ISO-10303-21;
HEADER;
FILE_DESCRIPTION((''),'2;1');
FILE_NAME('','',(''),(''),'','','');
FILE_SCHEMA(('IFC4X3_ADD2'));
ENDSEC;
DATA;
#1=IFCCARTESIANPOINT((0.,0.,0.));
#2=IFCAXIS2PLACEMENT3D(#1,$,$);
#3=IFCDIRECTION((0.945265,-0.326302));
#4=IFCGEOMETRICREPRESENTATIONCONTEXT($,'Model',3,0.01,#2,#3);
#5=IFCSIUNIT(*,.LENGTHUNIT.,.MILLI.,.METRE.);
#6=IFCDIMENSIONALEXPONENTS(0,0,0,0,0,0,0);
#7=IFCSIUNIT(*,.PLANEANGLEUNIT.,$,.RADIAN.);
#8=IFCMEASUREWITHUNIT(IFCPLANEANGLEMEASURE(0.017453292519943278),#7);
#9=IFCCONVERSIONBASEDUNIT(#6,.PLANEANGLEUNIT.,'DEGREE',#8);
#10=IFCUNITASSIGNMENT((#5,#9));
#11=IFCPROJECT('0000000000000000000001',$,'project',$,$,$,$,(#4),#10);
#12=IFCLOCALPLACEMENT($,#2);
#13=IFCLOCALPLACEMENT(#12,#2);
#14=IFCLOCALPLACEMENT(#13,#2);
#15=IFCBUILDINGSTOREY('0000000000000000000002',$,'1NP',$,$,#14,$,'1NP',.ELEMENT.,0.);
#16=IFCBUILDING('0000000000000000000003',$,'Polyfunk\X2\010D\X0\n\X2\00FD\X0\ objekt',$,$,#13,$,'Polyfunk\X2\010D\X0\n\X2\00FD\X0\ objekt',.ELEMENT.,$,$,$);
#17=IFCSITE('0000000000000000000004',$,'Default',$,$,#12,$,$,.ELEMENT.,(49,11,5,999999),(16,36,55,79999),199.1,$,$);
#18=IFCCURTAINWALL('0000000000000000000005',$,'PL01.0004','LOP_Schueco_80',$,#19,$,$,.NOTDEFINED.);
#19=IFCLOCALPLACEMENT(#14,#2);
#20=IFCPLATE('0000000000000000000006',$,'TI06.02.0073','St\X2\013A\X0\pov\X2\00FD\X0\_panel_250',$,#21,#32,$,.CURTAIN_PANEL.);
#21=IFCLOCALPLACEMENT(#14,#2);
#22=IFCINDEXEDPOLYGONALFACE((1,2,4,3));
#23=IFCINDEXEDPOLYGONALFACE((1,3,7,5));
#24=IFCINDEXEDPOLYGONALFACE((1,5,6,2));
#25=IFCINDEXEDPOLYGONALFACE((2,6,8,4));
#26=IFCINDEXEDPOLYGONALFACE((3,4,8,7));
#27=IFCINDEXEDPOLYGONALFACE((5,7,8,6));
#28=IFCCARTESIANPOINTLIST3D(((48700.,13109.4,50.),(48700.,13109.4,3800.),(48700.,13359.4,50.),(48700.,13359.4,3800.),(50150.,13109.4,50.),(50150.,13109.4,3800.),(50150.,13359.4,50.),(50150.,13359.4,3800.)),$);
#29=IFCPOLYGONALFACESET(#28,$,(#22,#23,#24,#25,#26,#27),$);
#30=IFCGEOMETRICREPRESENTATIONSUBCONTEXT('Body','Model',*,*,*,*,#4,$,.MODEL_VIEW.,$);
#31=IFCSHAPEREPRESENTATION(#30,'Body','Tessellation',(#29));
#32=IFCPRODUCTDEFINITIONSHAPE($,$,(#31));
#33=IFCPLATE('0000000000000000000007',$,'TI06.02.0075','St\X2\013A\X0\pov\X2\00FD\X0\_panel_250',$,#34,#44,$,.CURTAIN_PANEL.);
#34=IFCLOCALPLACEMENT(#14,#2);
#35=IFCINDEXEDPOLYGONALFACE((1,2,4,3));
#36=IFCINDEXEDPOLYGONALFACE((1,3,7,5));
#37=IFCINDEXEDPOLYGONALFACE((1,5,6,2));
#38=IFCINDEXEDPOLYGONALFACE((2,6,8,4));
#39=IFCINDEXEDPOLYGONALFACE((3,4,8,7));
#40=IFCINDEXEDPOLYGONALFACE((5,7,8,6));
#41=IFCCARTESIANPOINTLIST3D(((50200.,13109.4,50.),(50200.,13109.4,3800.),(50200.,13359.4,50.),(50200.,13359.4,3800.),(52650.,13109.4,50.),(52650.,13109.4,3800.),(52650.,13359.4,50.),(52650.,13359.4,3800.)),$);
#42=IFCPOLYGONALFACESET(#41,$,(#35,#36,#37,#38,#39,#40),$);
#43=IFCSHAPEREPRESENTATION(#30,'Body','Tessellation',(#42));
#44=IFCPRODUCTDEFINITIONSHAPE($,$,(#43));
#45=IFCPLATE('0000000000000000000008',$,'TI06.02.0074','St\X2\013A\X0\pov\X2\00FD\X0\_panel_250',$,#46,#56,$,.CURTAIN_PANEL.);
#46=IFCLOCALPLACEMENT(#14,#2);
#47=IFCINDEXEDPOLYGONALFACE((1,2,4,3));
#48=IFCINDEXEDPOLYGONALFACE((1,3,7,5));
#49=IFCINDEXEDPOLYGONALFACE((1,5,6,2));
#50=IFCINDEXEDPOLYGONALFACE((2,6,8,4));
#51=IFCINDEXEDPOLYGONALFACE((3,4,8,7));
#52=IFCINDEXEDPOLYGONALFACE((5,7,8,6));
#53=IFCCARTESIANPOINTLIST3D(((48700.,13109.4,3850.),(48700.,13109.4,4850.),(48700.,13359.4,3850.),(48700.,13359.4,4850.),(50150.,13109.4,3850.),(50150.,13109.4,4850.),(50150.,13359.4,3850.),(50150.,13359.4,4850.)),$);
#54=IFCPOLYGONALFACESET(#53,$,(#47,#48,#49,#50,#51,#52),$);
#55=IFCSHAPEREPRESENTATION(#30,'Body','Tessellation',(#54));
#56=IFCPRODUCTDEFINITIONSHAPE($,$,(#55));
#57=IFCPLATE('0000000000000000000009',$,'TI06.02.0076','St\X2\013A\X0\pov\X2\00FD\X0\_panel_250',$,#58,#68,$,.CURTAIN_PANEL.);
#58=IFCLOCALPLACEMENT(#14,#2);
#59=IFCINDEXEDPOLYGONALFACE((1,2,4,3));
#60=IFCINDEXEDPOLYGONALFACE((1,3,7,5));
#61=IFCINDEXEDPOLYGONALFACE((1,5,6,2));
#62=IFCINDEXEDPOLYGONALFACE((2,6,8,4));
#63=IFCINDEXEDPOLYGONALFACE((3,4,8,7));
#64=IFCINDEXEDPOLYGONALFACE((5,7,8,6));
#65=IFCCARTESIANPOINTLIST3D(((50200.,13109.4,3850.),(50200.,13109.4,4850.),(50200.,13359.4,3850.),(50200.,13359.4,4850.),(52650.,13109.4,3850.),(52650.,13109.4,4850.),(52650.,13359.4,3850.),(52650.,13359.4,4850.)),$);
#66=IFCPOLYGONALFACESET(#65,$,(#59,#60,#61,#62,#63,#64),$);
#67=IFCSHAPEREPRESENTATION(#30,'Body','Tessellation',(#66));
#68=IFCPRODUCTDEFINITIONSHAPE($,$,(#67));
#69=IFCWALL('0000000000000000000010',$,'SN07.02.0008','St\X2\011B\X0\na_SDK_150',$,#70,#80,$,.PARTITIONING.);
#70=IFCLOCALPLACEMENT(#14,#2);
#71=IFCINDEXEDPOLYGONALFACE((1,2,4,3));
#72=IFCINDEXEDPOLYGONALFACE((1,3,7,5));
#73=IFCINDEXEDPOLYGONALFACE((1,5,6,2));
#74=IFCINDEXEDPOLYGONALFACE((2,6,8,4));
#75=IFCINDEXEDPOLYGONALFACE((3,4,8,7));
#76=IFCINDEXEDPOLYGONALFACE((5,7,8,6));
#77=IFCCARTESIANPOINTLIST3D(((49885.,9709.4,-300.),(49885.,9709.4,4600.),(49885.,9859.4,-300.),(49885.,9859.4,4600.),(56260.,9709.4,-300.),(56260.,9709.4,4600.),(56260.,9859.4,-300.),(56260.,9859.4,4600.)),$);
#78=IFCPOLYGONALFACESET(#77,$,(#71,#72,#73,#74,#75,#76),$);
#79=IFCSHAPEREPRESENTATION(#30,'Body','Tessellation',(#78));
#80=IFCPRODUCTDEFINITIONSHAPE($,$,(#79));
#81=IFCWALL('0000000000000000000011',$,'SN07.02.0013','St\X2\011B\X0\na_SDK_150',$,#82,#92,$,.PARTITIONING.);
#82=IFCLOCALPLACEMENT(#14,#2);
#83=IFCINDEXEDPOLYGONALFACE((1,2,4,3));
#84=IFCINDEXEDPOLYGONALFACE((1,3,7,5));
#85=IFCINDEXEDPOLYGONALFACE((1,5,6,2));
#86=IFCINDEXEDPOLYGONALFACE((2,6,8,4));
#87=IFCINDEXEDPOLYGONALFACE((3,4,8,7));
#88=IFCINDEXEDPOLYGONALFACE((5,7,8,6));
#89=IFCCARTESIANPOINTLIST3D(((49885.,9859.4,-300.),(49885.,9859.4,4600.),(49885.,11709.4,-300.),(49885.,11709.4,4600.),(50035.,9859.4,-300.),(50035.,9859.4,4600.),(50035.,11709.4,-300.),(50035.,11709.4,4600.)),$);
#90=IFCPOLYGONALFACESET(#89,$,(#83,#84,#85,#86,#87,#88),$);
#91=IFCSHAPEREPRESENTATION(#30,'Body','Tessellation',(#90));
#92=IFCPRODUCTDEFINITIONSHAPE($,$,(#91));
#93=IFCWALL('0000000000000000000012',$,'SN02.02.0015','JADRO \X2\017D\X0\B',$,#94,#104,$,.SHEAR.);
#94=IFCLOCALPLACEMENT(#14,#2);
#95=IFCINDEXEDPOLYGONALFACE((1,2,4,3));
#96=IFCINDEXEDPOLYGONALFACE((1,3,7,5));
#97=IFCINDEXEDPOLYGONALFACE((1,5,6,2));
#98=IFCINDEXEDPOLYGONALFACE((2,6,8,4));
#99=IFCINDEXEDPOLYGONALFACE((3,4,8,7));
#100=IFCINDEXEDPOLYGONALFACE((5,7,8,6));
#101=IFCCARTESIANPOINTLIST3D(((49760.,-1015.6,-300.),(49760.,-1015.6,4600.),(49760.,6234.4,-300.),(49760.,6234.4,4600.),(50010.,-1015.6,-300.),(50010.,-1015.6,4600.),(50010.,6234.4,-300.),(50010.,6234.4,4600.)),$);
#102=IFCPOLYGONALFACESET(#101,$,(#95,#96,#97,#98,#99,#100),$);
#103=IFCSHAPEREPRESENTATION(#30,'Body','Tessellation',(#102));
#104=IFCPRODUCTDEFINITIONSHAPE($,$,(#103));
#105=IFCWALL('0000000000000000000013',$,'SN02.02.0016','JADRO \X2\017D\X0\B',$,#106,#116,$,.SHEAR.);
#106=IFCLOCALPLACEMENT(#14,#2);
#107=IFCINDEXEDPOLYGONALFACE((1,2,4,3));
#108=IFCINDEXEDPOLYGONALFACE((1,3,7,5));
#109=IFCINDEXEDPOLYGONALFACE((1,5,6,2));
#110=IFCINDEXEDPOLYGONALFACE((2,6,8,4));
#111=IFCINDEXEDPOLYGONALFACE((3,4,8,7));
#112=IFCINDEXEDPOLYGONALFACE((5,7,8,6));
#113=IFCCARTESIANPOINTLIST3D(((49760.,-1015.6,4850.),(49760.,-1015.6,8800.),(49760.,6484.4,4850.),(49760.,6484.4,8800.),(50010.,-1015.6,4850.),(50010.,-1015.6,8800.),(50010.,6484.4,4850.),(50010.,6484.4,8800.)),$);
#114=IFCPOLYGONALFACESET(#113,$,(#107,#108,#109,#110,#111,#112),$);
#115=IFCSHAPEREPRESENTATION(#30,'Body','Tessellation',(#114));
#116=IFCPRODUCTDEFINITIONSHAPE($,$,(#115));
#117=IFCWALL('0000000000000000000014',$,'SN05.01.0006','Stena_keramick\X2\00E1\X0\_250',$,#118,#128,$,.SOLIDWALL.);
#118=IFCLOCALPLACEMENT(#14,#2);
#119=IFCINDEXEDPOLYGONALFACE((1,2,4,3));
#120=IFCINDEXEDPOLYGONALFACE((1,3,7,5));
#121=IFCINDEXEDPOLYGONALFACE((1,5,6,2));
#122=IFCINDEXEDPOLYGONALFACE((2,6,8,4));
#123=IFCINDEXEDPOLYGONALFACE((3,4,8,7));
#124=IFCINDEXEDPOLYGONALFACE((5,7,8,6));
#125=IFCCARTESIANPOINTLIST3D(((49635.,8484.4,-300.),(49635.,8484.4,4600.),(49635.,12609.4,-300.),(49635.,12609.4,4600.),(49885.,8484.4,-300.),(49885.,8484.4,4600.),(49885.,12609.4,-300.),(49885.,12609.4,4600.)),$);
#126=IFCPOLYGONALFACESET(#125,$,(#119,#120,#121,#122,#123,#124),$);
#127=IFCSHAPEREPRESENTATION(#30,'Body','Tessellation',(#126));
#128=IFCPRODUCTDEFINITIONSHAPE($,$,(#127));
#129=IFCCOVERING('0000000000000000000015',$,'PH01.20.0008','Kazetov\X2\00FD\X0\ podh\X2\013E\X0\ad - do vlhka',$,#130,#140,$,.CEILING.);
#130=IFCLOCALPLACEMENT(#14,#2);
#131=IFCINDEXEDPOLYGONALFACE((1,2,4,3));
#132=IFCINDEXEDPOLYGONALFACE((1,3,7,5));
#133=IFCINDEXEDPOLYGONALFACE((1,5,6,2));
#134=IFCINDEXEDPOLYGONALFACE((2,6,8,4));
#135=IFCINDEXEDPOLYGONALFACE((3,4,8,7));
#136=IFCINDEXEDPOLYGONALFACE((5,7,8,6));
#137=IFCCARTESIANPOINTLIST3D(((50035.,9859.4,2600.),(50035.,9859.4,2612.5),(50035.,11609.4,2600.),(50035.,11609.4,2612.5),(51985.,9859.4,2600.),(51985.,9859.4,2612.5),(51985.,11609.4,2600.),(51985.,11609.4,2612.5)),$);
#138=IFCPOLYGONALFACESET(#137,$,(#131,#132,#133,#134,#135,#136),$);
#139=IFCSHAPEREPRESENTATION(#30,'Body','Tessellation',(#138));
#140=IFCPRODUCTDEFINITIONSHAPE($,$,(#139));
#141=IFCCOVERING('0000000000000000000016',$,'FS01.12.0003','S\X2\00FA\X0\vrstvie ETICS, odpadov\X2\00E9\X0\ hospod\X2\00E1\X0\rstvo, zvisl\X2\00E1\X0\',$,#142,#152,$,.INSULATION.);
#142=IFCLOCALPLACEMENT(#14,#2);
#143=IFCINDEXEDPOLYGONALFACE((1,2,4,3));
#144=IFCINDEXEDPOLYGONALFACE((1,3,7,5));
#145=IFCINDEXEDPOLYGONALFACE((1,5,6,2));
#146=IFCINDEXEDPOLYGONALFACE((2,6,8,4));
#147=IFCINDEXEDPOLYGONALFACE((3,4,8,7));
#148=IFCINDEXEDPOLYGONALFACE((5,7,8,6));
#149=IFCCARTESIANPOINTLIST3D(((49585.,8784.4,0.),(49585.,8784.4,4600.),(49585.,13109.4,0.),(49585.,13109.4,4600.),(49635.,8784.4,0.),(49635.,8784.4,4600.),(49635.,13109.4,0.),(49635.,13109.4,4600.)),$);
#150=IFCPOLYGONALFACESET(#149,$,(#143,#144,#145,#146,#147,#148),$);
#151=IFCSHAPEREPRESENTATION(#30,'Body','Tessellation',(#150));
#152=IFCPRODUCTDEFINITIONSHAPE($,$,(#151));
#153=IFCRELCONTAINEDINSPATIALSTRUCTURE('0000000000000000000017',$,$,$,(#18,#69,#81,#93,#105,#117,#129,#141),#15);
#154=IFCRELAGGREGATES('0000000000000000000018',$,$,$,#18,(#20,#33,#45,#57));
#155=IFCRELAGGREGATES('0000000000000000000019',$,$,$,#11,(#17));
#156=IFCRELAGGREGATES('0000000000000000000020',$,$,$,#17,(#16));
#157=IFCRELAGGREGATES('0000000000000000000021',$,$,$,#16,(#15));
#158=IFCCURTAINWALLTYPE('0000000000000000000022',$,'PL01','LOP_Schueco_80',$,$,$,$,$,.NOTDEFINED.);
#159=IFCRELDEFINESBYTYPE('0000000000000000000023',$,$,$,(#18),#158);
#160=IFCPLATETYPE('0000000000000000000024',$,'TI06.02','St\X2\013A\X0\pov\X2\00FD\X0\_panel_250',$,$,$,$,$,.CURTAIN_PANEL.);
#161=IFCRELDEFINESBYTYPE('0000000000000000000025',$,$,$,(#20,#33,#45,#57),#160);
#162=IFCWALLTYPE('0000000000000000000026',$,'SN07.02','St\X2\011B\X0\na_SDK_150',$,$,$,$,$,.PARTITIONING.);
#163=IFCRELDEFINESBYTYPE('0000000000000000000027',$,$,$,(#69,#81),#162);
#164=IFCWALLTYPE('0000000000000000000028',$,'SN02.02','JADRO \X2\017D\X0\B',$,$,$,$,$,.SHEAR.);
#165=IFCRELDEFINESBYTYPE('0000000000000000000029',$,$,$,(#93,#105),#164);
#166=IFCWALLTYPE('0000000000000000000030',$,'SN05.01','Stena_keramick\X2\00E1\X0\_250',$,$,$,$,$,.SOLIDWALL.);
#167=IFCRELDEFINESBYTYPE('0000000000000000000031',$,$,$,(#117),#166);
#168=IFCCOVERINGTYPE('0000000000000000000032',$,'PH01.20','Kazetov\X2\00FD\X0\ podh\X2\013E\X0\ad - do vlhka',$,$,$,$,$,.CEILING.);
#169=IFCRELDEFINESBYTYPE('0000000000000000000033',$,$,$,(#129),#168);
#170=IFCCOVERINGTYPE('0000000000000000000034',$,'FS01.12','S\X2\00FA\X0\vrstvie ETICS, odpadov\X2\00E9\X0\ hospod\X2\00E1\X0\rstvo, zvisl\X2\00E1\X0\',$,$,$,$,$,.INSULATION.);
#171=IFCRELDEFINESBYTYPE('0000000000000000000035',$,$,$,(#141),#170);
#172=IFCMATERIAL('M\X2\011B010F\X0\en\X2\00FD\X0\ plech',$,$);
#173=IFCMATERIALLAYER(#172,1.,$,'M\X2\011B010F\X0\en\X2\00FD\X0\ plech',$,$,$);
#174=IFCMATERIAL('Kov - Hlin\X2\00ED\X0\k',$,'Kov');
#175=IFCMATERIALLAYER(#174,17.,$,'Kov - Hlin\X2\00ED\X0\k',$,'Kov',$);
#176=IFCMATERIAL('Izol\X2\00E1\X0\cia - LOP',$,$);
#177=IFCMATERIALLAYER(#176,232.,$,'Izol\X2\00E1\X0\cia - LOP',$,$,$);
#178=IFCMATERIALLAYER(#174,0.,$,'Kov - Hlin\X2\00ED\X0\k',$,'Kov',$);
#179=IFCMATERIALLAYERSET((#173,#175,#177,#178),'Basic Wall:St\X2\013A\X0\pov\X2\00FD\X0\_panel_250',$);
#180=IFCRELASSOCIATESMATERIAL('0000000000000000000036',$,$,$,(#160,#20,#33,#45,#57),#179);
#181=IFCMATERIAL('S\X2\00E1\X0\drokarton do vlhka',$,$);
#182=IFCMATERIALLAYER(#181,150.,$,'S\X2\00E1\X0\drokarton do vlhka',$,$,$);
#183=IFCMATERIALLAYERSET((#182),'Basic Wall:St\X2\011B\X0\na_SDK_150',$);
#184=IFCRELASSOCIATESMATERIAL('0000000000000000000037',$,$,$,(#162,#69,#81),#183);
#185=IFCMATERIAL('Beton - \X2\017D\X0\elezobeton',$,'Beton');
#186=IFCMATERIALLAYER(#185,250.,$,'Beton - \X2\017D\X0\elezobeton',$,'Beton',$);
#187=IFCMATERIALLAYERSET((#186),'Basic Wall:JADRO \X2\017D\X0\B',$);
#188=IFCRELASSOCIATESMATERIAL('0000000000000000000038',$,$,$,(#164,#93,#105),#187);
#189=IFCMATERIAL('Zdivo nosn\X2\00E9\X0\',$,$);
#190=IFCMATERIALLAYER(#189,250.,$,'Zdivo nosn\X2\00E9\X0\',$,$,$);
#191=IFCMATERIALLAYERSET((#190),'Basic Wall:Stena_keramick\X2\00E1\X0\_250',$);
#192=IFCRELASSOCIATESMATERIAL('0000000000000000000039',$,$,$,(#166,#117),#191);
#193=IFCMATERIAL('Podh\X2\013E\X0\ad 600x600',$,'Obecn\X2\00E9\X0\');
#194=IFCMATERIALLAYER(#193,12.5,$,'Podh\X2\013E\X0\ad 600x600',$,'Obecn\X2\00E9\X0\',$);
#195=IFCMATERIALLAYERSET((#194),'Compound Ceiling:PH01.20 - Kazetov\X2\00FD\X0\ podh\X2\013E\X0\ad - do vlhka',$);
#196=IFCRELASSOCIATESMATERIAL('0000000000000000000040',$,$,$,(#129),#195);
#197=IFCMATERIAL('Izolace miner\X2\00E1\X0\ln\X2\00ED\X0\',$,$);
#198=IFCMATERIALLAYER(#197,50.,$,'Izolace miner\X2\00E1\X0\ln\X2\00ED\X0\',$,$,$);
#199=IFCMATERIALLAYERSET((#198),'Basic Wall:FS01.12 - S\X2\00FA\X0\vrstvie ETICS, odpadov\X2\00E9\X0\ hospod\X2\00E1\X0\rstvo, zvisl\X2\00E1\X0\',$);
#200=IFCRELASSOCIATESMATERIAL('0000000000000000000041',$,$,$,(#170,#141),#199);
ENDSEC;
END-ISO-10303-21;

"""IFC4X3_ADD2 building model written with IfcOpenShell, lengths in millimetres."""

from ifc_helpers import new_model, entity, si_unit, converted_unit, direction, frame, frame_2d, origin, origin_2d_with_axis, place, context, subcontext, project, spatial, polyline, rectangle, extrude, clip, bounded_halfspace, material, layer, layer_set, layer_usage, type_object, element, aggregate, save


model = new_model("IFC4X3_ADD2")

# Units and contexts
model_context = context("Model", 3, precision=0.01, world=origin(), true_north=direction((0.945265, -0.326302)))
body_context = subcontext(model_context, "Body", "Model", "MODEL_VIEW")
ifc_project = project(units=[si_unit("LENGTHUNIT", "METRE", prefix="MILLI"), converted_unit("PLANEANGLEUNIT", "DEGREE", entity("IfcPlaneAngleMeasure", 0.017453292519943278), si_unit("PLANEANGLEUNIT", "RADIAN"), dimensions=[0, 0, 0, 0, 0, 0, 0])], contexts=[model_context])

# Site, building, storey
site_placement = place(None, origin())
site = spatial("IfcSite", under=ifc_project, at=site_placement, Name="Default", CompositionType="ELEMENT", RefLatitude=(49, 11, 5, 999999), RefLongitude=(16, 36, 55, 79999), RefElevation=199.1)
building_placement = place(site_placement, origin())
building = spatial("IfcBuilding", under=site, at=building_placement, Name="Polyfunkčný objekt", LongName="Polyfunkčný objekt", CompositionType="ELEMENT")
storey_placement = place(building_placement, origin())
storey = spatial("IfcBuildingStorey", under=building, at=storey_placement, Name="1NP", LongName="1NP", CompositionType="ELEMENT", Elevation=0.0)

# Curtain wall, plates
curtain_wall_type = type_object("IfcCurtainWallType", Name="PL01", Description="LOP_Schueco_80", PredefinedType="NOTDEFINED")
curtain_wall_placement = place(storey_placement, origin())
curtain_wall = element("IfcCurtainWall", 1, at=curtain_wall_placement, inside=storey, type_object=curtain_wall_type, Name="PL01.0004", Description="LOP_Schueco_80", PredefinedType="NOTDEFINED")
ifc_material_1 = material(Name="Měďený plech")
ifc_layer_1 = layer(ifc_material_1, 1.0, Name="Měďený plech")
ifc_material_2 = material(Name="Kov - Hliník", Category="Kov")
ifc_layer_2 = layer(ifc_material_2, 17.0, Name="Kov - Hliník", Category="Kov")
ifc_material_3 = material(Name="Izolácia - LOP")
ifc_layer_3 = layer(ifc_material_3, 232.0, Name="Izolácia - LOP")
ifc_layer_4 = layer(ifc_material_2, 0.0, Name="Kov - Hliník", Category="Kov")
ifc_layer_set_1 = layer_set([ifc_layer_1, ifc_layer_2, ifc_layer_3, ifc_layer_4], Name="Basic Wall:Stĺpový_panel_250")
ifc_layer_usage_1 = layer_usage(ifc_layer_set_1, "AXIS2", "NEGATIVE", 125.0)
plate_type = type_object("IfcPlateType", Name="TI06.02", Description="Stĺpový_panel_250", PredefinedType="CURTAIN_PANEL", material=ifc_layer_set_1)
plate_1_placement = place(storey_placement, frame((48700.0, 13234.4, 50.0)))
plate_1 = element("IfcPlate", 2, at=plate_1_placement, type_object=plate_type, material=ifc_layer_usage_1, Name="TI06.02.0073", Description="Stĺpový_panel_250", PredefinedType="CURTAIN_PANEL", context=body_context, shape_type="SweptSolid", body=[
    extrude(rectangle(XDim=250.0, YDim=1450.0, at=frame_2d((0.0, 0.0), x_axis=(1.0, 0.0))), frame((725.0, 0.0, 0.0), z_axis=(0.0, 0.0, 1.0), x_axis=(0.0, 1.0, 0.0)), (0.0, 0.0, 1.0), 3750.0),
])
ifc_layer_usage_2 = layer_usage(ifc_layer_set_1, "AXIS2", "NEGATIVE", 125.0)
plate_2_placement = place(storey_placement, frame((50200.0, 13234.4, 50.0)))
plate_2 = element("IfcPlate", 3, at=plate_2_placement, type_object=plate_type, material=ifc_layer_usage_2, Name="TI06.02.0075", Description="Stĺpový_panel_250", PredefinedType="CURTAIN_PANEL", context=body_context, shape_type="SweptSolid", body=[
    extrude(rectangle(XDim=250.0, YDim=2450.0, at=origin_2d_with_axis()), frame((1225.0, 0.0, 0.0), z_axis=(0.0, 0.0, 1.0), x_axis=(0.0, 1.0, 0.0)), (0.0, 0.0, 1.0), 3750.0),
])
ifc_layer_usage_3 = layer_usage(ifc_layer_set_1, "AXIS2", "NEGATIVE", 125.0)
plate_3_placement = place(storey_placement, frame((48700.0, 13234.4, 3850.0)))
plate_3 = element("IfcPlate", 4, at=plate_3_placement, type_object=plate_type, material=ifc_layer_usage_3, Name="TI06.02.0074", Description="Stĺpový_panel_250", PredefinedType="CURTAIN_PANEL", context=body_context, shape_type="SweptSolid", body=[
    extrude(rectangle(XDim=250.0, YDim=1450.0, at=frame_2d((0.0, 0.0), x_axis=(1.0, 0.0))), frame((725.0, 0.0, 0.0), z_axis=(0.0, 0.0, 1.0), x_axis=(0.0, 1.0, 0.0)), (0.0, 0.0, 1.0), 1000.0),
])
ifc_layer_usage_4 = layer_usage(ifc_layer_set_1, "AXIS2", "NEGATIVE", 125.0)
plate_4_placement = place(storey_placement, frame((50200.0, 13234.4, 3850.0)))
plate_4 = element("IfcPlate", 5, at=plate_4_placement, type_object=plate_type, material=ifc_layer_usage_4, Name="TI06.02.0076", Description="Stĺpový_panel_250", PredefinedType="CURTAIN_PANEL", context=body_context, shape_type="SweptSolid", body=[
    extrude(rectangle(XDim=250.0, YDim=2450.0, at=origin_2d_with_axis()), frame((1225.0, 0.0, 0.0), z_axis=(0.0, 0.0, 1.0), x_axis=(0.0, 1.0, 0.0)), (0.0, 0.0, 1.0), 1000.0),
])
aggregate(curtain_wall, [plate_1, plate_2, plate_3, plate_4])

# Walls
ifc_material_4 = material(Name="Sádrokarton do vlhka")
ifc_layer_5 = layer(ifc_material_4, 150.0, Name="Sádrokarton do vlhka")
ifc_layer_set_2 = layer_set([ifc_layer_5], Name="Basic Wall:Stěna_SDK_150")
wall_type_1 = type_object("IfcWallType", Name="SN07.02", Description="Stěna_SDK_150", PredefinedType="PARTITIONING", material=ifc_layer_set_2)
wall_1_placement = place(storey_placement, frame((49885.0, 9784.4, -300.0)))
element("IfcWall", 6, at=wall_1_placement, inside=storey, type_object=wall_type_1, material=ifc_layer_set_2, Name="SN07.02.0008", Description="Stěna_SDK_150", PredefinedType="PARTITIONING", context=body_context, shape_type="Clipping", body=[
    clip(clip(extrude(rectangle(XDim=6375.0, YDim=150.0, at=frame_2d((3187.5, 0.0), x_axis=(-1.0, 0.0))), origin(), (0.0, 0.0, 1.0), 4900.0), bounded_halfspace(frame((0.0, -75.0, 4900.0), z_axis=(0.0, 0.0, -1.0), x_axis=(1.0, 0.0, 0.0)), True, frame((0.0, -75.0, 4900.0)), polyline([(0.0, 0.0), (6375.0, 0.0), (6375.0, 150.0), (2250.0, 150.0), (2100.0, 150.0), (1200.0, 150.0), (1050.0, 150.0), (150.0, 150.0), (0.0, 150.0), (0.0, 0.0)]))), bounded_halfspace(frame((6375.0, -75.0, 0.0), z_axis=(0.0, 0.0, 1.0), x_axis=(0.0, 1.0, 0.0)), True, frame((6375.0, -75.0, 0.0)), polyline([(0.0, 0.0), (0.0, 150.0), (-4125.0, 150.0), (-4275.0, 150.0), (-5175.0, 150.0), (-5325.0, 150.0), (-6225.0, 150.0), (-6375.0, 150.0), (-6375.0, 0.0), (0.0, 0.0)]))),
])
wall_2_placement = place(storey_placement, frame((49960.0, 9859.4, -300.0), z_axis=(0.0, 0.0, 1.0), x_axis=(0.0, 1.0, 0.0)))
element("IfcWall", 7, at=wall_2_placement, inside=storey, type_object=wall_type_1, material=ifc_layer_set_2, Name="SN07.02.0013", Description="Stěna_SDK_150", PredefinedType="PARTITIONING", context=body_context, shape_type="Clipping", body=[
    clip(clip(extrude(rectangle(XDim=1850.0, YDim=150.0, at=frame_2d((925.0, 0.0), x_axis=(-1.0, 0.0))), origin(), (0.0, 0.0, 1.0), 4900.0), bounded_halfspace(frame((0.0, -75.0, 4900.0), z_axis=(0.0, 0.0, -1.0), x_axis=(0.0, -1.0, 0.0)), True, frame((0.0, -75.0, 4900.0)), polyline([(0.0, 0.0), (1750.0, 0.0), (1850.0, 0.0), (1850.0, 150.0), (0.0, 150.0), (0.0, 0.0)]))), bounded_halfspace(frame((1850.0, -75.0, 0.0)), True, frame((1850.0, -75.0, 0.0)), polyline([(0.0, 0.0), (0.0, 150.0), (-1850.0, 150.0), (-1850.0, 0.0), (-100.0, 0.0), (0.0, 0.0)]))),
])
ifc_material_5 = material(Name="Beton - Železobeton", Category="Beton")
ifc_layer_6 = layer(ifc_material_5, 250.0, Name="Beton - Železobeton", Category="Beton")
ifc_layer_set_3 = layer_set([ifc_layer_6], Name="Basic Wall:JADRO ŽB")
wall_type_2 = type_object("IfcWallType", Name="SN02.02", Description="JADRO ŽB", PredefinedType="SHEAR", material=ifc_layer_set_3)
wall_3_placement = place(storey_placement, frame((49885.0, 6234.4, -300.0), z_axis=(0.0, 0.0, 1.0), x_axis=(0.0, -1.0, 0.0)))
element("IfcWall", 8, at=wall_3_placement, inside=storey, type_object=wall_type_2, material=ifc_layer_set_3, Name="SN02.02.0015", Description="JADRO ŽB", PredefinedType="SHEAR", context=body_context, shape_type="Clipping", body=[
    clip(clip(extrude(rectangle(XDim=7250.0, YDim=250.0, at=frame_2d((3625.0, 0.0), x_axis=(-1.0, 0.0))), origin(), (0.0, 0.0, 1.0), 4900.0), bounded_halfspace(frame((0.0, -125.0, 4900.0), z_axis=(0.0, 0.0, -1.0), x_axis=(0.0, 1.0, 0.0)), True, frame((0.0, -125.0, 4900.0)), polyline([(0.0, 0.0), (800.0, 0.0), (950.0, 0.0), (7250.0, 0.0), (7250.0, 250.0), (0.0, 250.0), (0.0, 0.0)]))), bounded_halfspace(frame((7250.0, -125.0, 0.0), z_axis=(0.0, 0.0, 1.0), x_axis=(-1.0, 0.0, 0.0)), True, frame((7250.0, -125.0, 0.0)), polyline([(0.0, 0.0), (0.0, 250.0), (-7250.0, 250.0), (-7250.0, 0.0), (-6450.0, 0.0), (-6300.0, 0.0), (0.0, 0.0)]))),
])
wall_4_placement = place(storey_placement, frame((49885.0, 6484.4, 4850.0), z_axis=(0.0, 0.0, 1.0), x_axis=(0.0, -1.0, 0.0)))
element("IfcWall", 9, at=wall_4_placement, inside=storey, type_object=wall_type_2, material=ifc_layer_set_3, Name="SN02.02.0016", Description="JADRO ŽB", PredefinedType="SHEAR", context=body_context, shape_type="Clipping", body=[
    clip(clip(extrude(rectangle(XDim=7500.0, YDim=250.0, at=frame_2d((3750.0, 0.0), x_axis=(-1.0, 0.0))), origin(), (0.0, 0.0, 1.0), 3950.0), bounded_halfspace(frame((7500.0, -125.0, 0.0), z_axis=(0.0, 0.0, 1.0), x_axis=(0.0, -1.0, 0.0)), True, frame((7500.0, -125.0, 0.0)), polyline([(0.0, 0.0), (0.0, 250.0), (-7500.0, 250.0), (-7500.0, 0.0), (-7250.0, 0.0), (-6450.0, 0.0), (-6300.0, 0.0), (0.0, 0.0)]))), bounded_halfspace(frame((0.0, -125.0, 3950.0), z_axis=(0.0, 0.0, -1.0), x_axis=(0.0, 1.0, 0.0)), True, frame((0.0, -125.0, 3950.0)), polyline([(0.0, 0.0), (250.0, 0.0), (1050.0, 0.0), (1200.0, 0.0), (7500.0, 0.0), (7500.0, 250.0), (0.0, 250.0), (0.0, 0.0)]))),
])
ifc_material_6 = material(Name="Zdivo nosné")
ifc_layer_7 = layer(ifc_material_6, 250.0, Name="Zdivo nosné")
ifc_layer_set_4 = layer_set([ifc_layer_7], Name="Basic Wall:Stena_keramická_250")
wall_type_3 = type_object("IfcWallType", Name="SN05.01", Description="Stena_keramická_250", PredefinedType="SOLIDWALL", material=ifc_layer_set_4)
wall_5_placement = place(storey_placement, frame((49760.0, 12609.4, -300.0), z_axis=(0.0, 0.0, 1.0), x_axis=(0.0, -1.0, 0.0)))
element("IfcWall", 10, at=wall_5_placement, inside=storey, type_object=wall_type_3, material=ifc_layer_set_4, Name="SN05.01.0006", Description="Stena_keramická_250", PredefinedType="SOLIDWALL", context=body_context, shape_type="Clipping", body=[
    clip(clip(extrude(rectangle(XDim=4125.0, YDim=250.0, at=frame_2d((2062.5, 0.0), x_axis=(-1.0, 0.0))), origin(), (0.0, 0.0, 1.0), 4900.0), bounded_halfspace(frame((0.0, -125.0, 4900.0), z_axis=(0.0, 0.0, -1.0), x_axis=(0.0, 1.0, 0.0)), True, frame((0.0, -125.0, 4900.0)), polyline([(0.0, 0.0), (3875.0, 0.0), (4125.0, 0.0), (4125.0, 250.0), (0.0, 250.0), (0.0, 0.0)]))), bounded_halfspace(frame((4125.0, -125.0, 0.0), z_axis=(0.0, 0.0, 1.0), x_axis=(-1.0, 0.0, 0.0)), True, frame((4125.0, -125.0, 0.0)), polyline([(0.0, 0.0), (0.0, 250.0), (-4125.0, 250.0), (-4125.0, 0.0), (-250.0, 0.0), (0.0, 0.0)]))),
])

# Coverings
ifc_material_7 = material(Name="Podhľad 600x600", Category="Obecné")
ifc_layer_8 = layer(ifc_material_7, 12.5, Name="Podhľad 600x600", Category="Obecné")
ifc_layer_set_5 = layer_set([ifc_layer_8], Name="Compound Ceiling:PH01.20 - Kazetový podhľad - do vlhka")
ifc_layer_usage_5 = layer_usage(ifc_layer_set_5, "AXIS3", "NEGATIVE", 0.0)
covering_type_1 = type_object("IfcCoveringType", Name="PH01.20", Description="Kazetový podhľad - do vlhka", PredefinedType="CEILING")
covering_1_placement = place(storey_placement, frame((50035.0, 9859.4, 2600.0)))
element("IfcCovering", 11, at=covering_1_placement, inside=storey, type_object=covering_type_1, material=ifc_layer_usage_5, Name="PH01.20.0008", Description="Kazetový podhľad - do vlhka", PredefinedType="CEILING", context=body_context, shape_type="SweptSolid", body=[
    extrude(rectangle(XDim=1950.0, YDim=1750.0, at=origin_2d_with_axis()), frame((975.0, 875.0, 0.0), z_axis=(0.0, 0.0, 1.0), x_axis=(-1.0, 0.0, 0.0)), (0.0, 0.0, 1.0), 12.5),
])
ifc_material_8 = material(Name="Izolace minerální")
ifc_layer_9 = layer(ifc_material_8, 50.0, Name="Izolace minerální")
ifc_layer_set_6 = layer_set([ifc_layer_9], Name="Basic Wall:FS01.12 - Súvrstvie ETICS, odpadové hospodárstvo, zvislá")
covering_type_2 = type_object("IfcCoveringType", Name="FS01.12", Description="Súvrstvie ETICS, odpadové hospodárstvo, zvislá", PredefinedType="INSULATION", material=ifc_layer_set_6)
covering_2_placement = place(storey_placement, frame((49610.0, 8784.4, 0.0), z_axis=(0.0, 0.0, 1.0), x_axis=(0.0, 1.0, 0.0)))
element("IfcCovering", 12, at=covering_2_placement, inside=storey, type_object=covering_type_2, material=ifc_layer_set_6, Name="FS01.12.0003", Description="Súvrstvie ETICS, odpadové hospodárstvo, zvislá", PredefinedType="INSULATION", context=body_context, shape_type="SweptSolid", body=[
    extrude(rectangle(XDim=4325.0, YDim=50.0, at=frame_2d((2162.5, 0.0), x_axis=(-1.0, 0.0))), origin(), (0.0, 0.0, 1.0), 4600.0),
])

save(model, "model.ifc")
